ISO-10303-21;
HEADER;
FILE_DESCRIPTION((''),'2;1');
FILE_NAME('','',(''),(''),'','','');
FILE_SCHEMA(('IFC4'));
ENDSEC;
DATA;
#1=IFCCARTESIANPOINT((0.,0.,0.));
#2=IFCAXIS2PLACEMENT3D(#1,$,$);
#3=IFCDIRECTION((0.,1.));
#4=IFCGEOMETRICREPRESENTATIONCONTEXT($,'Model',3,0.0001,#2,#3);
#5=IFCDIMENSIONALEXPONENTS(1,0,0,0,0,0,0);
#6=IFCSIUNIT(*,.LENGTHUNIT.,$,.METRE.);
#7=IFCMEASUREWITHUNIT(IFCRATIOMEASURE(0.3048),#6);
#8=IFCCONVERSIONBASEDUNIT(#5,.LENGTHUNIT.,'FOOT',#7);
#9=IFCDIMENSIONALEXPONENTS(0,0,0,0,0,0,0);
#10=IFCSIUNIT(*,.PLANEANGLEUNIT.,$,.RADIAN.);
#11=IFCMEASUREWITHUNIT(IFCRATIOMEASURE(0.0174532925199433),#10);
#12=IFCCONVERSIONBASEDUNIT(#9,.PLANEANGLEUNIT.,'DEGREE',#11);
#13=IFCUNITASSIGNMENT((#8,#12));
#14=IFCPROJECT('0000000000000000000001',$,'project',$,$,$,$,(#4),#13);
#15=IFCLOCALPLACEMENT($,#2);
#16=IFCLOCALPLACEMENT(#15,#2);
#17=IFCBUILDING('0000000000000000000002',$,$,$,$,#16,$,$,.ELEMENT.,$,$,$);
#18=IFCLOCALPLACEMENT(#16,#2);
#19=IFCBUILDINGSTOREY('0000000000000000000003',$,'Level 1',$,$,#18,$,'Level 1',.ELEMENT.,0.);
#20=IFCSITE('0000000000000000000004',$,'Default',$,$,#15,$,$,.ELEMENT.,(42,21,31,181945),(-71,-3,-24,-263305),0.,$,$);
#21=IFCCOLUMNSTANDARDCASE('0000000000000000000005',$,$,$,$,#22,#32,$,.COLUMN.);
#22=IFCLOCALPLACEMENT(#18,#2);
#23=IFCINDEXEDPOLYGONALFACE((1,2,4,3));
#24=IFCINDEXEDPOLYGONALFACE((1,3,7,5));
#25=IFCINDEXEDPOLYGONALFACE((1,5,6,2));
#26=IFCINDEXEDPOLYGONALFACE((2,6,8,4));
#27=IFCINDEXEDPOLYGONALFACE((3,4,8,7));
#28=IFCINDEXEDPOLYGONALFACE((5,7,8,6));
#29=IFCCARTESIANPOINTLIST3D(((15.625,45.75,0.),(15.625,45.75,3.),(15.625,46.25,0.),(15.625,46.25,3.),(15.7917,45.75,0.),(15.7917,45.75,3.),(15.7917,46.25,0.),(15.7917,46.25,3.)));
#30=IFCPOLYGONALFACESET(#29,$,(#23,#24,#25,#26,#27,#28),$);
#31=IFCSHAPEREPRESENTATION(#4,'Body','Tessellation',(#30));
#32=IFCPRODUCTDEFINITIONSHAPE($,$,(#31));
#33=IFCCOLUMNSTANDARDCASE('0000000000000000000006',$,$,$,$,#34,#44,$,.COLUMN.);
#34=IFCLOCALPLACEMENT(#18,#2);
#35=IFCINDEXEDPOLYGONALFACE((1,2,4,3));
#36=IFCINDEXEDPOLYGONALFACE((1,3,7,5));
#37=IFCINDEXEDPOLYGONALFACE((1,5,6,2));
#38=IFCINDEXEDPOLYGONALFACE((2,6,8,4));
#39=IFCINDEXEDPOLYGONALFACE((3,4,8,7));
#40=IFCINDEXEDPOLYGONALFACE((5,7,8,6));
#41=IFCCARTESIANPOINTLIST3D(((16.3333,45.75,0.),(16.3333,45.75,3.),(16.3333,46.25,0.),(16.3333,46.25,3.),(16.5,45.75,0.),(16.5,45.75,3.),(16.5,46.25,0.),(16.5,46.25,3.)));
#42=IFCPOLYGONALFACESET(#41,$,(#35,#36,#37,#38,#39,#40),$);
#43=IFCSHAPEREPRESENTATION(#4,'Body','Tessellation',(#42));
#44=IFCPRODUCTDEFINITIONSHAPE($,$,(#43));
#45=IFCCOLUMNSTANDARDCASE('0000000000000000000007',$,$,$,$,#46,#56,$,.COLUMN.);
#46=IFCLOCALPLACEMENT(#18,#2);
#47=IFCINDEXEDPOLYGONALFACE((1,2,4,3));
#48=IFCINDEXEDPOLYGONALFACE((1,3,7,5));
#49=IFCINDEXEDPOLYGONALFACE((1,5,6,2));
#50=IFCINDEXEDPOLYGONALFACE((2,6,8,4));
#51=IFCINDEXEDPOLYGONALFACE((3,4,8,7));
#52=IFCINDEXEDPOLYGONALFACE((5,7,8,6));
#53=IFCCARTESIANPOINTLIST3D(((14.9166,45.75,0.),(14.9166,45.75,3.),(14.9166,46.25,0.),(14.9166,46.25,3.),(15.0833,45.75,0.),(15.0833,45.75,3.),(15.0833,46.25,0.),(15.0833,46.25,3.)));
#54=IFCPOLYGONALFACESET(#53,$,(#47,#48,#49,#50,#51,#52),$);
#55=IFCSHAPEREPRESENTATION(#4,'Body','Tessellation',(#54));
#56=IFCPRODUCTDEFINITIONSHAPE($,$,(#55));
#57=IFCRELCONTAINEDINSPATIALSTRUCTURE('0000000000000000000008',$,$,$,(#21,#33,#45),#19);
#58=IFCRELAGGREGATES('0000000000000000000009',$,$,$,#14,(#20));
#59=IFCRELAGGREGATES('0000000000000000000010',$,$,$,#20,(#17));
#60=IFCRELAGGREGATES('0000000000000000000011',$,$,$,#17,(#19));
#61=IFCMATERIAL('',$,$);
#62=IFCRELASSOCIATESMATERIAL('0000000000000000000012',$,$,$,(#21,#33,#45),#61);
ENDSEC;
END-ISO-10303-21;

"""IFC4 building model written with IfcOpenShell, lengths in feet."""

from ifc_helpers import new_model, entity, si_unit, converted_unit, direction, frame, origin, place, context, project, spatial, rectangle, extrude, material, element, save


model = new_model("IFC4")

# Units and contexts
model_context = context("Model", 3, precision=0.0001, world=origin(), true_north=direction((0.0, 1.0)))
ifc_project = project(units=[converted_unit("LENGTHUNIT", "FOOT", entity("IfcRatioMeasure", 0.3048), si_unit("LENGTHUNIT", "METRE"), dimensions=[1, 0, 0, 0, 0, 0, 0]), converted_unit("PLANEANGLEUNIT", "DEGREE", entity("IfcRatioMeasure", 0.0174532925199433), si_unit("PLANEANGLEUNIT", "RADIAN"), dimensions=[0, 0, 0, 0, 0, 0, 0])], contexts=[model_context])

# Site, building, storey
site_placement = place(None, origin())
site = spatial("IfcSite", under=ifc_project, at=site_placement, Name="Default", CompositionType="ELEMENT", RefLatitude=(42, 21, 31, 181945), RefLongitude=(-71, -3, -24, -263305), RefElevation=0.0)
building_placement = place(site_placement, origin())
building = spatial("IfcBuilding", under=site, at=building_placement, CompositionType="ELEMENT")
storey_placement = place(building_placement, origin())
storey = spatial("IfcBuildingStorey", under=building, at=storey_placement, Name="Level 1", LongName="Level 1", CompositionType="ELEMENT", Elevation=0.0)

# Columns
placement_1 = place(storey_placement, frame((-0.25, 46.0, 0.0)))
ifc_material_1 = material(Name="")
for number, where, z_axis, x_axis in (
    (1, (15.9583, 0.0, 0.0), (0.0, 0.0, 1.0), (1.0, 0.0, 0.0)),
    (2, (16.6667, 0.0, 0.0), (0.0, 0.0, 1.0), (1.0, 0.0, 0.0)),
    (3, (15.25, 0.0, 0.0), (0.0, 0.0, 1.0), (1.0, 0.0, 0.0)),
):
    element("IfcColumnStandardCase", number, at=place(placement_1, frame(where, z_axis=z_axis, x_axis=x_axis)), inside=storey, material=ifc_material_1, PredefinedType="COLUMN", context=model_context, shape_type="SweptSolid", body=[
        extrude(rectangle(XDim=0.1667, YDim=0.5), origin(), (0.0, 0.0, 1.0), 3.0),
    ])

save(model, "model.ifc")
